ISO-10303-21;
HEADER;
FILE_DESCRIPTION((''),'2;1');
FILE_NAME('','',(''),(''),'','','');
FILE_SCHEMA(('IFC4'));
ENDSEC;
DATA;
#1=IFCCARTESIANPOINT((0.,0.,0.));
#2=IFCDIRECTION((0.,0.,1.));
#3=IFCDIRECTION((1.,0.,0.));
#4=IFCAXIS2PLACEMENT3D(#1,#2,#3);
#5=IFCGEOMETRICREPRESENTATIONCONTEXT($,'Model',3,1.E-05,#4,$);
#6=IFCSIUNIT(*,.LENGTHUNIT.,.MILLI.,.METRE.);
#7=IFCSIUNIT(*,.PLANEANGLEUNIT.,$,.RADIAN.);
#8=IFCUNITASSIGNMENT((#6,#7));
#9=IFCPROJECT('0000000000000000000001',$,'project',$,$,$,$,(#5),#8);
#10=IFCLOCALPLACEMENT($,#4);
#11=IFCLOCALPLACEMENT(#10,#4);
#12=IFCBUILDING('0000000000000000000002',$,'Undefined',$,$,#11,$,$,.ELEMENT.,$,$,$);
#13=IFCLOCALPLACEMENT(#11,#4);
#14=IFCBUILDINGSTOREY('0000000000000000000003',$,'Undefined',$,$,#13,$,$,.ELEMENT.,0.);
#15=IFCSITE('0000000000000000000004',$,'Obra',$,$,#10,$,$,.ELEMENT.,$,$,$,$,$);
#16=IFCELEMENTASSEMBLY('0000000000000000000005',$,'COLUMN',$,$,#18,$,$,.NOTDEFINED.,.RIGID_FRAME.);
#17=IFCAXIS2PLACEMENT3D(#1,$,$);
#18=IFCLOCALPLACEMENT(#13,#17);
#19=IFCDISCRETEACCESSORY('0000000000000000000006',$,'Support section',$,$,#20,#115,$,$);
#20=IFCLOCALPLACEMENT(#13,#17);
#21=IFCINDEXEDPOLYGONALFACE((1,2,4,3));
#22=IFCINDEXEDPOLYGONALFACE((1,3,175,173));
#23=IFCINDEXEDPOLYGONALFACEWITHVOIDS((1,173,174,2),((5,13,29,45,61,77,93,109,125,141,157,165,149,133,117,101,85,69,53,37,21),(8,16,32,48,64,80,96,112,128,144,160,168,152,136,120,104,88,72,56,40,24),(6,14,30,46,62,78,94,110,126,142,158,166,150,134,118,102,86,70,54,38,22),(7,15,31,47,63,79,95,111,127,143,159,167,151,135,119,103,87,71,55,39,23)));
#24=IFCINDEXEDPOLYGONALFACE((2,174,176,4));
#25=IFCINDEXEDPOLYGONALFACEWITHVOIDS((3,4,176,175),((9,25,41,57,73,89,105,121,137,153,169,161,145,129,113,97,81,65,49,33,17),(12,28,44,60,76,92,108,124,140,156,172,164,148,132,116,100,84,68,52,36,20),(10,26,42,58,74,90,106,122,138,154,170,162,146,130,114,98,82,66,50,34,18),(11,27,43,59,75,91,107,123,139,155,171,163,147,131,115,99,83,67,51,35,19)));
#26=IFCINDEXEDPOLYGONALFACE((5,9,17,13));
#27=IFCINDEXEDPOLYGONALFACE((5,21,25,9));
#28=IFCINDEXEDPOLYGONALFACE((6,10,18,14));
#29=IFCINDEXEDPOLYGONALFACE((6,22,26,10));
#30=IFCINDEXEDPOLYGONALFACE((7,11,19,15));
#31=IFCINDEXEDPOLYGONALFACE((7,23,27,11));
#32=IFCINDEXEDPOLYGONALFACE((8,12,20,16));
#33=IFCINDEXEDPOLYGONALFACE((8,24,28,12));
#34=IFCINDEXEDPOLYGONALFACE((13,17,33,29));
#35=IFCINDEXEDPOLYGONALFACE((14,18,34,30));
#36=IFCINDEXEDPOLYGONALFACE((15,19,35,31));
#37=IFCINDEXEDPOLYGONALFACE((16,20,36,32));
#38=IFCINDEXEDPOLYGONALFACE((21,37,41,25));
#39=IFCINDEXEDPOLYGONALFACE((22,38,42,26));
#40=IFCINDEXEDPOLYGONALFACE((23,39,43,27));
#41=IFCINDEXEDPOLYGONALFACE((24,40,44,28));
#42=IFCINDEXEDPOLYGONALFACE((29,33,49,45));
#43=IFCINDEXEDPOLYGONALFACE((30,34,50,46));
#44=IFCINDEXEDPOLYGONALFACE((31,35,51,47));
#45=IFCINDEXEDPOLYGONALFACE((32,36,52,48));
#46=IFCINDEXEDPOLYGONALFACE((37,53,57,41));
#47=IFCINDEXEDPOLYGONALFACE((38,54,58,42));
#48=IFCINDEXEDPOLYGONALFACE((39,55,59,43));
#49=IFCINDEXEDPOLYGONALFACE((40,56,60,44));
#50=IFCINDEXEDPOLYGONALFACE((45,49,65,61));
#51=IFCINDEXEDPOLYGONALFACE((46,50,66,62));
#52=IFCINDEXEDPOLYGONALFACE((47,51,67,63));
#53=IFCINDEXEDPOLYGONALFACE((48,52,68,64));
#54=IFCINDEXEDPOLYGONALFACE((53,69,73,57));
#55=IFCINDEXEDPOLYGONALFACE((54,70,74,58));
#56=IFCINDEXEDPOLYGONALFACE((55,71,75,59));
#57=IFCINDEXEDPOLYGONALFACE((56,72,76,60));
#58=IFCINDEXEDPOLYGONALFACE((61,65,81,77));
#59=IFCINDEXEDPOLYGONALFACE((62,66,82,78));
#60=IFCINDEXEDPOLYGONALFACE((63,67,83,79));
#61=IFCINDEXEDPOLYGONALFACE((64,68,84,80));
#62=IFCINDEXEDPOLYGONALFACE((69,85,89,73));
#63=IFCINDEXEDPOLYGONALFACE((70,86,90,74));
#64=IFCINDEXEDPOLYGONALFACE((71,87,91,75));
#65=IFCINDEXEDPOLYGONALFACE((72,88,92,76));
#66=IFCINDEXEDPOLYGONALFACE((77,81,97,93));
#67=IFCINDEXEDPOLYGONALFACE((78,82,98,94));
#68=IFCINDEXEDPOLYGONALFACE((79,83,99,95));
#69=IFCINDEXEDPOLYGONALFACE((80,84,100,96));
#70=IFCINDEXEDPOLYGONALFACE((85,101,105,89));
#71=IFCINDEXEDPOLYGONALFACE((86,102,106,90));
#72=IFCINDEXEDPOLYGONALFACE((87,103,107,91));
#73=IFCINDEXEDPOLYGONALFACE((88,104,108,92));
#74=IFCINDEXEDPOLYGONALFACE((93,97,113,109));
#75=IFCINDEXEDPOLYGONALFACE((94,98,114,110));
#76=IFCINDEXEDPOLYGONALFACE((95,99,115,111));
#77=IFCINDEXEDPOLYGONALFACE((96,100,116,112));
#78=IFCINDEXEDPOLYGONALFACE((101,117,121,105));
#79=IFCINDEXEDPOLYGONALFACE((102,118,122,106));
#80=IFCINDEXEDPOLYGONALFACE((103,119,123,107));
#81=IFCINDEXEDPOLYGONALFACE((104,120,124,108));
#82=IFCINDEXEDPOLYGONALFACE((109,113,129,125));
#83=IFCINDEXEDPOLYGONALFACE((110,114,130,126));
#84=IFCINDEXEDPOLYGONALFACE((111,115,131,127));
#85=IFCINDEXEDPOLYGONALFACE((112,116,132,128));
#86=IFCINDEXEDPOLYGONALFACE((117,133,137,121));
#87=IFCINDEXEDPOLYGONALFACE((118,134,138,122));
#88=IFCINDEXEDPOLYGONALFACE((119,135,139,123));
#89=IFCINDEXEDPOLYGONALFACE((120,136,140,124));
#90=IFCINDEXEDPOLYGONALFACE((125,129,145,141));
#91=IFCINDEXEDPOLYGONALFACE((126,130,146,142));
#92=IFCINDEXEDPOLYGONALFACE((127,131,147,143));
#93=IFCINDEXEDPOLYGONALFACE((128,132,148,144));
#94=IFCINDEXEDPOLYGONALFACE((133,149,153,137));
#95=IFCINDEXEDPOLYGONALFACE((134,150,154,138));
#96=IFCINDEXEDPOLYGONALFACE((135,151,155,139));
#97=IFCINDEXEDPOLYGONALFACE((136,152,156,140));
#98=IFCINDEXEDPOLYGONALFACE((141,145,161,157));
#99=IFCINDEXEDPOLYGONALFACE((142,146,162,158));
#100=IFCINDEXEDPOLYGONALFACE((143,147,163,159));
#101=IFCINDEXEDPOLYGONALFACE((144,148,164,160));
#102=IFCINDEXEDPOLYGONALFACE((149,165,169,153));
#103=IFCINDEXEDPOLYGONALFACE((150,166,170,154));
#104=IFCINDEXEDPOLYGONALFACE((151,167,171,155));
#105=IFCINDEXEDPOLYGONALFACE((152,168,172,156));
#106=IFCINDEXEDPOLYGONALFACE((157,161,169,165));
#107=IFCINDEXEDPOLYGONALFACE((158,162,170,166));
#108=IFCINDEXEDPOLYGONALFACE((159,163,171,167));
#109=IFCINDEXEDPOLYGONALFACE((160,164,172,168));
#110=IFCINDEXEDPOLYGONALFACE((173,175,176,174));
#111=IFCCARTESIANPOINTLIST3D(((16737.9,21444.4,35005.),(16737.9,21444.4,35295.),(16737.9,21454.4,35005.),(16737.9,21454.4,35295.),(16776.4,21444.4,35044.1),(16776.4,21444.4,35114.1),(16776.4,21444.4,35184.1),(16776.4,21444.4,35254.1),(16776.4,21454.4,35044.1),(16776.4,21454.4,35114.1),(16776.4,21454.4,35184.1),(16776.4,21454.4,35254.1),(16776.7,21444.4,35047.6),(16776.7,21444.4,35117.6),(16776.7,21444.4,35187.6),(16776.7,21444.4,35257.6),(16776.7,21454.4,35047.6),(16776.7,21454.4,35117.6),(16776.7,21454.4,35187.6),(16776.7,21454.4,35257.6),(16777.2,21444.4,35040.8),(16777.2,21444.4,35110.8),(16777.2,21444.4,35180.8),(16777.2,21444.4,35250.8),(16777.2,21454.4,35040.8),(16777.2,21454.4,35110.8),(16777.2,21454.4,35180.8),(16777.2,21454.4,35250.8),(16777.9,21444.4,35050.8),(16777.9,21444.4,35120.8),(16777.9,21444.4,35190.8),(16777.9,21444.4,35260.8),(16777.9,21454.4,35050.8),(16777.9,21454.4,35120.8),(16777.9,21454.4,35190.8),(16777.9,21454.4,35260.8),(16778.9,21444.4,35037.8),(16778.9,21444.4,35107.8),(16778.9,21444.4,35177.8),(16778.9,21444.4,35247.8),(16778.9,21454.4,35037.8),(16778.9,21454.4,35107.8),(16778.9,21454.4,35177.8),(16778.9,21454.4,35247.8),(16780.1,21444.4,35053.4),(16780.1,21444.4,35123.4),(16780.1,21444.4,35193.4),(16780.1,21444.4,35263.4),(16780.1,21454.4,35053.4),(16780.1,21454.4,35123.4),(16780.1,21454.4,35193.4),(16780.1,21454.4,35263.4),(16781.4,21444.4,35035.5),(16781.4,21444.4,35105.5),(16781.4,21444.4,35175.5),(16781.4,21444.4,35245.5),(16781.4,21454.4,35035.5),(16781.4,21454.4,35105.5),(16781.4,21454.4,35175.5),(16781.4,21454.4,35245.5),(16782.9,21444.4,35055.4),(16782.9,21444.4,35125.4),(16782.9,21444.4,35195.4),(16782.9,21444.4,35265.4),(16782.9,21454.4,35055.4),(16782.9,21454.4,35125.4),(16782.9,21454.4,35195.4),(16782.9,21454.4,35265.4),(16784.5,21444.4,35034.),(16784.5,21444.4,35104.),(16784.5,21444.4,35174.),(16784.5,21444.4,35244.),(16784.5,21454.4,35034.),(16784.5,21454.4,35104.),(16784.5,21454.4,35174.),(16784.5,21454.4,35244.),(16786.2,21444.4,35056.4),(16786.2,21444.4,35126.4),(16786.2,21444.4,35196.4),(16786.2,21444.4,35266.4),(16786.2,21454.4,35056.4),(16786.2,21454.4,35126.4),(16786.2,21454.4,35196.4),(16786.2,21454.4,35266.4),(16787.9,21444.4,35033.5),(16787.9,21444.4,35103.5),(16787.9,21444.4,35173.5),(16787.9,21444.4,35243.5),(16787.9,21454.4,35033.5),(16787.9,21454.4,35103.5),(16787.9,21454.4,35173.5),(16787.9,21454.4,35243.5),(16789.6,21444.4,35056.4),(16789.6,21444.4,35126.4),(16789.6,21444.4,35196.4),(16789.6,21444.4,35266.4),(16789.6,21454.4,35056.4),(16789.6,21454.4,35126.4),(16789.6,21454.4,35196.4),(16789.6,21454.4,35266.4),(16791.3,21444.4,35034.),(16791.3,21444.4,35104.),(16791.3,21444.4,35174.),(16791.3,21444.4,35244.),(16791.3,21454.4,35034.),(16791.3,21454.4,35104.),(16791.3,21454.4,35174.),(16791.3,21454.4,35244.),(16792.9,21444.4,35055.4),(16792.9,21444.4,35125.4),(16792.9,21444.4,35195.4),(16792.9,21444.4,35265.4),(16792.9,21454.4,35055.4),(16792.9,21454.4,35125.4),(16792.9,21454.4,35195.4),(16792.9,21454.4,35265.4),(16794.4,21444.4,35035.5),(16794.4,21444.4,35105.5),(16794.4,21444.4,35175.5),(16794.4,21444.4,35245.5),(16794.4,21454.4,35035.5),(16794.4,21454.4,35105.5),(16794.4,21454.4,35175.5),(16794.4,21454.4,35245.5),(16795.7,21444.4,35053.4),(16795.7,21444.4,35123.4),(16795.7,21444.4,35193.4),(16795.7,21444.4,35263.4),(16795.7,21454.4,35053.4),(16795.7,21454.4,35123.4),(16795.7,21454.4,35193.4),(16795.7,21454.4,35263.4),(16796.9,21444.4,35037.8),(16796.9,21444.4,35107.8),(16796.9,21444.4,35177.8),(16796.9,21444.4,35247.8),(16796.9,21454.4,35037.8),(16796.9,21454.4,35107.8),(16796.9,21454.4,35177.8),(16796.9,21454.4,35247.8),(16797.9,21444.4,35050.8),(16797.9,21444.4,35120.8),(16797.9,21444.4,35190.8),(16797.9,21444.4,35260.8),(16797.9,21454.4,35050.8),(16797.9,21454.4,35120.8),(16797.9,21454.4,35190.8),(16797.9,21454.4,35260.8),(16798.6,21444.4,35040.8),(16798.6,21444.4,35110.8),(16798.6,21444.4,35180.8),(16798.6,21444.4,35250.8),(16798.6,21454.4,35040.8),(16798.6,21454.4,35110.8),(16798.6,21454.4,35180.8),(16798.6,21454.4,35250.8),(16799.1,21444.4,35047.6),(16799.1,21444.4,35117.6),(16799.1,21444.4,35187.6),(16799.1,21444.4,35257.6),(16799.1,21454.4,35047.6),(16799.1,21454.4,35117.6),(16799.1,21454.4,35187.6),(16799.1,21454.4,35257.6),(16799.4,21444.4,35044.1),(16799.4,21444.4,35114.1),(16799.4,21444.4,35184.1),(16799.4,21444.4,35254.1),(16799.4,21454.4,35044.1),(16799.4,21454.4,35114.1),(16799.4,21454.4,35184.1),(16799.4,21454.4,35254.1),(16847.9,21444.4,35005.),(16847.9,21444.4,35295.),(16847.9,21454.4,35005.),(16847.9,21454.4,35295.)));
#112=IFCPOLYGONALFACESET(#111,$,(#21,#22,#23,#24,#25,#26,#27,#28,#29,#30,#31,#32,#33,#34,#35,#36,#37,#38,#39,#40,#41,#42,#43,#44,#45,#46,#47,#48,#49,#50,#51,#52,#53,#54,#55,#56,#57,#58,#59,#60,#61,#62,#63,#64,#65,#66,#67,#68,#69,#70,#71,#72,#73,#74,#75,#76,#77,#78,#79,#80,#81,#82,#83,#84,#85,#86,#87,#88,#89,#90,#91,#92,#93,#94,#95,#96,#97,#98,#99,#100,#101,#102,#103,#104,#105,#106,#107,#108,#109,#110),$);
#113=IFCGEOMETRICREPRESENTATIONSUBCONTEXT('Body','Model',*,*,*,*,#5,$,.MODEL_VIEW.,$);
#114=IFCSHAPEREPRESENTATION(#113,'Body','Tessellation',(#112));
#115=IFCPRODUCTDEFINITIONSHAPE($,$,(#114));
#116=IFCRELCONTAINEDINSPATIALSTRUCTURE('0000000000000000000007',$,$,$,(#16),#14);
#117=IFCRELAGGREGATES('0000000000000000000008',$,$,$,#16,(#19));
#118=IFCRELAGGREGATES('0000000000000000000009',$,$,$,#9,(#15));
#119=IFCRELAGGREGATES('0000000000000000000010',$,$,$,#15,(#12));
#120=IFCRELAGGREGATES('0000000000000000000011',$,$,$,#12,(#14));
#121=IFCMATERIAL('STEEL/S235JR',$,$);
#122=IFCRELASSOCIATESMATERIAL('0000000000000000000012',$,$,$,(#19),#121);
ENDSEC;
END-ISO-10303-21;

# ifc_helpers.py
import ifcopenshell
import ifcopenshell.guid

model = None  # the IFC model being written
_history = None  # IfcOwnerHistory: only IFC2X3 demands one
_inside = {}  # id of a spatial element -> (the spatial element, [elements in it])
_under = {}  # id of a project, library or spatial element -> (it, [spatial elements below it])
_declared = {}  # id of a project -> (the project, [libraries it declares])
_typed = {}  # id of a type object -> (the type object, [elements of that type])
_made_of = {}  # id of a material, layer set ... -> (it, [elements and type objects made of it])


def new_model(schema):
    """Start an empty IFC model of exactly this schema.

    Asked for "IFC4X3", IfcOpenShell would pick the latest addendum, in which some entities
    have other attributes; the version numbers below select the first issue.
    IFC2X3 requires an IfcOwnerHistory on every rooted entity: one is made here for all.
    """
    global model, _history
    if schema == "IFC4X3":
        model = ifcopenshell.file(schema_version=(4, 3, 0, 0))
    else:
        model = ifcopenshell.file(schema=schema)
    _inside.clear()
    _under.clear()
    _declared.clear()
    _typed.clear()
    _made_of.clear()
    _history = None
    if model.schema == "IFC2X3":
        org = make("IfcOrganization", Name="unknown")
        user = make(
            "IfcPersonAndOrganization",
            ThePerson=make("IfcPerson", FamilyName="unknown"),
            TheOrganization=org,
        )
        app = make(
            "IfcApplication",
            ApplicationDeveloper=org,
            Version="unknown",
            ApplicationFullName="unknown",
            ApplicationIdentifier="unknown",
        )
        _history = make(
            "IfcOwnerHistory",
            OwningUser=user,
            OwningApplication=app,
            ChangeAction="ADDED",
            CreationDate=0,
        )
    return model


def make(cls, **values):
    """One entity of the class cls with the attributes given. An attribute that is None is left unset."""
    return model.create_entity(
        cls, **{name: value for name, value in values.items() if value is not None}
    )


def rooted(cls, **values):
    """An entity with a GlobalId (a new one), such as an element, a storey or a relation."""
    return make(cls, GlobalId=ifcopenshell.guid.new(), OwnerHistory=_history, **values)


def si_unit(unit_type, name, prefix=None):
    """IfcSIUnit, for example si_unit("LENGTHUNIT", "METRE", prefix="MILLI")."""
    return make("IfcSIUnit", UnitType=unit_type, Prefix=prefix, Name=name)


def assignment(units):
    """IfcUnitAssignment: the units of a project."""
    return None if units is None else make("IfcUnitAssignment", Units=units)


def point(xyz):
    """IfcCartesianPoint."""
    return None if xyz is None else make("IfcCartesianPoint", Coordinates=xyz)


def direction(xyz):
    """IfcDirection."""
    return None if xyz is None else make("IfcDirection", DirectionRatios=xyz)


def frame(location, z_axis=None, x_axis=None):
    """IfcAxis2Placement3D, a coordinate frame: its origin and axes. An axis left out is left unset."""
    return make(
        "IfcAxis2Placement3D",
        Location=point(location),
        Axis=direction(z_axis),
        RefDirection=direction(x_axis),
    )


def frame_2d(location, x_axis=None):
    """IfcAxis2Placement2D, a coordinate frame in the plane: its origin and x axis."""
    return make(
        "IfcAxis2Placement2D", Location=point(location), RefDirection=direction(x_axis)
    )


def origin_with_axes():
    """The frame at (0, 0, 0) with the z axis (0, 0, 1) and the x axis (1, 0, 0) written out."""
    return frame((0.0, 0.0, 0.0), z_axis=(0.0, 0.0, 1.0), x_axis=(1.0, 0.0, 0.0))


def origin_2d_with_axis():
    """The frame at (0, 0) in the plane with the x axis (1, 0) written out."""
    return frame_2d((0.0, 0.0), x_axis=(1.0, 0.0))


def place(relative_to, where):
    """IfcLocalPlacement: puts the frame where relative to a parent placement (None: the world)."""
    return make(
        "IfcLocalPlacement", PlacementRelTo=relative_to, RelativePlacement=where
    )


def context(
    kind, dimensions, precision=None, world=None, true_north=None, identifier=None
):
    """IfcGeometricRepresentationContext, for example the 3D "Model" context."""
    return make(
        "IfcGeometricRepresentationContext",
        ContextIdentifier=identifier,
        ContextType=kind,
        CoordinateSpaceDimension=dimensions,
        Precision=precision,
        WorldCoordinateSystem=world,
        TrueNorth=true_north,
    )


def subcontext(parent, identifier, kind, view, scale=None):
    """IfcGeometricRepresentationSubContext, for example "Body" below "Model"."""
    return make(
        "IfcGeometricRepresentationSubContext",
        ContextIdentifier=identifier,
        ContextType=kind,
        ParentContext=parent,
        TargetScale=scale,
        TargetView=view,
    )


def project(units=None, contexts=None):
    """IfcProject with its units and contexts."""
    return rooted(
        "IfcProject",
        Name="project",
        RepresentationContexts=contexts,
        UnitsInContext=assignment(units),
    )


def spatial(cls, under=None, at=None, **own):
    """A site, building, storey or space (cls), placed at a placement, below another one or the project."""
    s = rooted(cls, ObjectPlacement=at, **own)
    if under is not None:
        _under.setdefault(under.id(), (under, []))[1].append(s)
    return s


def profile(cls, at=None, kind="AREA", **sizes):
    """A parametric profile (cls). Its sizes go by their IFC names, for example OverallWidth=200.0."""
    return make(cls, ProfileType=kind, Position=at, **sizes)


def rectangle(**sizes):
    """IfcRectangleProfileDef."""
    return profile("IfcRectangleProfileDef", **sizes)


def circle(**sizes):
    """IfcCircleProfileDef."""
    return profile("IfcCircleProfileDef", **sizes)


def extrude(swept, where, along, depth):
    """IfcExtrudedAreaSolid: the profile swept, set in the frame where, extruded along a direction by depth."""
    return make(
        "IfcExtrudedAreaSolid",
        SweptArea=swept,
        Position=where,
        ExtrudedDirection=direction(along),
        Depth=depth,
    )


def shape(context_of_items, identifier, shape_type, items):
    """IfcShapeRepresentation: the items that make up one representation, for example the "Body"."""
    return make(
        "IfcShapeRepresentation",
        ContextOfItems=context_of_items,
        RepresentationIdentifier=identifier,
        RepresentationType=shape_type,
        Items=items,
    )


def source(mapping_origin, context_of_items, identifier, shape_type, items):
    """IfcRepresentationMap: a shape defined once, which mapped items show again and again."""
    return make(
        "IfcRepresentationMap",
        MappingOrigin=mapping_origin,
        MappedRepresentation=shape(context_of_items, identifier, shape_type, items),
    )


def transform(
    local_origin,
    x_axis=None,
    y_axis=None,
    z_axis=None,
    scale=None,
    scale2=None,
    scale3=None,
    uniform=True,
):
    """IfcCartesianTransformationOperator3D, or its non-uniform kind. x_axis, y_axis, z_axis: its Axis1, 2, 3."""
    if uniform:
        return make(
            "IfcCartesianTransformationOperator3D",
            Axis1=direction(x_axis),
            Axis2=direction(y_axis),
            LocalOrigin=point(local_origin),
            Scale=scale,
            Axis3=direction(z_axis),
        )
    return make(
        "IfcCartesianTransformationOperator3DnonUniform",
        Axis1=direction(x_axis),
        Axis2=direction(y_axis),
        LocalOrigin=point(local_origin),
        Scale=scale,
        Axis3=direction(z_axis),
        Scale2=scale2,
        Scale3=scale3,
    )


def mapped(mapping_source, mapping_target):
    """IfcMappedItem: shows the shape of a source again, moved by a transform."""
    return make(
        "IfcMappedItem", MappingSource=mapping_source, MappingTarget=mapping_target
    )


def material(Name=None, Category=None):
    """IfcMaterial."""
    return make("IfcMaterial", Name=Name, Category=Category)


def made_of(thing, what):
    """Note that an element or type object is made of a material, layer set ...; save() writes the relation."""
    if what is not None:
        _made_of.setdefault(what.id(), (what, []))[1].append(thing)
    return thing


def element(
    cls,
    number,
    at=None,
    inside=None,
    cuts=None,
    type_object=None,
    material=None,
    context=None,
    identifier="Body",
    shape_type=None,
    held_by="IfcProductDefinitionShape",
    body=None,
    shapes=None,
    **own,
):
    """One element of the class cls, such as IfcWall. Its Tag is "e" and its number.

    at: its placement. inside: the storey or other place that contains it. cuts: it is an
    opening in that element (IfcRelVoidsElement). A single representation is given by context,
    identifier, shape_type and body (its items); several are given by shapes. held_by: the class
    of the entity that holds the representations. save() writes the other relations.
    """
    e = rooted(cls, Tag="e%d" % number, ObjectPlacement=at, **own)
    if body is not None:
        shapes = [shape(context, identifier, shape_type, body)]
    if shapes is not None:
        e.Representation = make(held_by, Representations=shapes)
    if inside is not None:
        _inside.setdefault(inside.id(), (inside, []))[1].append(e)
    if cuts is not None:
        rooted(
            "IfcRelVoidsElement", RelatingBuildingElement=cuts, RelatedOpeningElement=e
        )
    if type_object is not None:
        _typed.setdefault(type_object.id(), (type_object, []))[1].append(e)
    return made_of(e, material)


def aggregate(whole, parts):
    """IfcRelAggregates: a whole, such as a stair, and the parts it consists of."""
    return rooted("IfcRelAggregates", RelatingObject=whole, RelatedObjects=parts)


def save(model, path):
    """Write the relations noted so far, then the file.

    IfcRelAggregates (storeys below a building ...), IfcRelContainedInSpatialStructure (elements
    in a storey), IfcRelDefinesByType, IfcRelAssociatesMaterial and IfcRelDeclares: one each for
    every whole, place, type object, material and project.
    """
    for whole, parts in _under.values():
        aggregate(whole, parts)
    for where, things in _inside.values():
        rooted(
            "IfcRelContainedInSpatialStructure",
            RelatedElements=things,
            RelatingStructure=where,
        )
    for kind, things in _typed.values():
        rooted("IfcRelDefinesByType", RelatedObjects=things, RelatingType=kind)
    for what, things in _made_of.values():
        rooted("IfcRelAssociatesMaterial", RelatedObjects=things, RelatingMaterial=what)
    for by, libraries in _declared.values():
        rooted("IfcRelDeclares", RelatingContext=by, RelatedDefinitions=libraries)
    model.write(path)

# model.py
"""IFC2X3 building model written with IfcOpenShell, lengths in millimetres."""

from ifc_helpers import new_model, si_unit, frame, origin_with_axes, origin_2d_with_axis, place, context, subcontext, project, spatial, rectangle, circle, extrude, source, transform, mapped, material, element, aggregate, save


model = new_model("IFC2X3")

# Units and contexts
model_context = context("Model", 3, precision=1e-05, world=origin_with_axes())
body_context = subcontext(model_context, "Body", "Model", "MODEL_VIEW")
ifc_project = project(units=[si_unit("LENGTHUNIT", "METRE", prefix="MILLI"), si_unit("PLANEANGLEUNIT", "RADIAN")], contexts=[model_context])

# Site, building, storey
site_placement = place(None, origin_with_axes())
site = spatial("IfcSite", under=ifc_project, at=site_placement, Name="Obra", CompositionType="ELEMENT")
building_placement = place(site_placement, origin_with_axes())
building = spatial("IfcBuilding", under=site, at=building_placement, Name="Undefined", CompositionType="ELEMENT")
storey_placement = place(building_placement, origin_with_axes())
storey = spatial("IfcBuildingStorey", under=building, at=storey_placement, Name="Undefined", CompositionType="ELEMENT", Elevation=0.0)

# Shared definitions
ifc_material_1 = material(Name="STEEL/S235JR")

# Shared definitions
shared_shape_1 = source(origin_with_axes(), body_context, "Body", "SweptSolid", [
    extrude(circle(Radius=11.5, at=origin_2d_with_axis()), frame((0.0, -14.4, 0.0), z_axis=(0.0, 1.0, 0.0), x_axis=(1.0, 0.0, 0.0)), (0.0, 0.0, 1.0), 10.2),
])

# Element assembly, discrete accessory, opening
assembly_1_placement = place(storey_placement, origin_with_axes())
assembly_1 = element("IfcElementAssembly", 1, at=assembly_1_placement, inside=storey, Name="COLUMN", AssemblyPlace="NOTDEFINED", PredefinedType="RIGID_FRAME")
discrete_accessory_1_placement = place(assembly_1_placement, frame((16792.9, 21449.4, 35005.0), z_axis=(0.0, 0.0, 1.0), x_axis=(1.0, 0.0, 0.0)))
discrete_accessory_1 = element("IfcDiscreteAccessory", 2, at=discrete_accessory_1_placement, material=ifc_material_1, Name="Support section", context=body_context, shape_type="SweptSolid", body=[
    extrude(rectangle(XDim=10.0, YDim=110.0, at=origin_2d_with_axis()), frame((0.0, 0.0, 290.0), z_axis=(0.0, 0.0, -1.0), x_axis=(0.0, 1.0, 0.0)), (0.0, 0.0, 1.0), 290.0),
])
opening_1_placement = place(assembly_1_placement, frame((16837.9, 21440.1, 35350.0), z_axis=(-1.0, 0.0, 0.0), x_axis=(0.0, 0.0, -1.0)))
element("IfcOpeningElement", 3, at=opening_1_placement, cuts=discrete_accessory_1, ObjectType="Opening", context=body_context, shape_type="MappedRepresentation", body=[
    mapped(shared_shape_1, transform((95.0, 0.0, 50.0))),
    mapped(shared_shape_1, transform((165.0, 0.0, 50.0))),
    mapped(shared_shape_1, transform((235.0, 0.0, 50.0))),
    mapped(shared_shape_1, transform((305.0, 0.0, 50.0))),
])

aggregate(assembly_1, [discrete_accessory_1])

save(model, "model.ifc")
